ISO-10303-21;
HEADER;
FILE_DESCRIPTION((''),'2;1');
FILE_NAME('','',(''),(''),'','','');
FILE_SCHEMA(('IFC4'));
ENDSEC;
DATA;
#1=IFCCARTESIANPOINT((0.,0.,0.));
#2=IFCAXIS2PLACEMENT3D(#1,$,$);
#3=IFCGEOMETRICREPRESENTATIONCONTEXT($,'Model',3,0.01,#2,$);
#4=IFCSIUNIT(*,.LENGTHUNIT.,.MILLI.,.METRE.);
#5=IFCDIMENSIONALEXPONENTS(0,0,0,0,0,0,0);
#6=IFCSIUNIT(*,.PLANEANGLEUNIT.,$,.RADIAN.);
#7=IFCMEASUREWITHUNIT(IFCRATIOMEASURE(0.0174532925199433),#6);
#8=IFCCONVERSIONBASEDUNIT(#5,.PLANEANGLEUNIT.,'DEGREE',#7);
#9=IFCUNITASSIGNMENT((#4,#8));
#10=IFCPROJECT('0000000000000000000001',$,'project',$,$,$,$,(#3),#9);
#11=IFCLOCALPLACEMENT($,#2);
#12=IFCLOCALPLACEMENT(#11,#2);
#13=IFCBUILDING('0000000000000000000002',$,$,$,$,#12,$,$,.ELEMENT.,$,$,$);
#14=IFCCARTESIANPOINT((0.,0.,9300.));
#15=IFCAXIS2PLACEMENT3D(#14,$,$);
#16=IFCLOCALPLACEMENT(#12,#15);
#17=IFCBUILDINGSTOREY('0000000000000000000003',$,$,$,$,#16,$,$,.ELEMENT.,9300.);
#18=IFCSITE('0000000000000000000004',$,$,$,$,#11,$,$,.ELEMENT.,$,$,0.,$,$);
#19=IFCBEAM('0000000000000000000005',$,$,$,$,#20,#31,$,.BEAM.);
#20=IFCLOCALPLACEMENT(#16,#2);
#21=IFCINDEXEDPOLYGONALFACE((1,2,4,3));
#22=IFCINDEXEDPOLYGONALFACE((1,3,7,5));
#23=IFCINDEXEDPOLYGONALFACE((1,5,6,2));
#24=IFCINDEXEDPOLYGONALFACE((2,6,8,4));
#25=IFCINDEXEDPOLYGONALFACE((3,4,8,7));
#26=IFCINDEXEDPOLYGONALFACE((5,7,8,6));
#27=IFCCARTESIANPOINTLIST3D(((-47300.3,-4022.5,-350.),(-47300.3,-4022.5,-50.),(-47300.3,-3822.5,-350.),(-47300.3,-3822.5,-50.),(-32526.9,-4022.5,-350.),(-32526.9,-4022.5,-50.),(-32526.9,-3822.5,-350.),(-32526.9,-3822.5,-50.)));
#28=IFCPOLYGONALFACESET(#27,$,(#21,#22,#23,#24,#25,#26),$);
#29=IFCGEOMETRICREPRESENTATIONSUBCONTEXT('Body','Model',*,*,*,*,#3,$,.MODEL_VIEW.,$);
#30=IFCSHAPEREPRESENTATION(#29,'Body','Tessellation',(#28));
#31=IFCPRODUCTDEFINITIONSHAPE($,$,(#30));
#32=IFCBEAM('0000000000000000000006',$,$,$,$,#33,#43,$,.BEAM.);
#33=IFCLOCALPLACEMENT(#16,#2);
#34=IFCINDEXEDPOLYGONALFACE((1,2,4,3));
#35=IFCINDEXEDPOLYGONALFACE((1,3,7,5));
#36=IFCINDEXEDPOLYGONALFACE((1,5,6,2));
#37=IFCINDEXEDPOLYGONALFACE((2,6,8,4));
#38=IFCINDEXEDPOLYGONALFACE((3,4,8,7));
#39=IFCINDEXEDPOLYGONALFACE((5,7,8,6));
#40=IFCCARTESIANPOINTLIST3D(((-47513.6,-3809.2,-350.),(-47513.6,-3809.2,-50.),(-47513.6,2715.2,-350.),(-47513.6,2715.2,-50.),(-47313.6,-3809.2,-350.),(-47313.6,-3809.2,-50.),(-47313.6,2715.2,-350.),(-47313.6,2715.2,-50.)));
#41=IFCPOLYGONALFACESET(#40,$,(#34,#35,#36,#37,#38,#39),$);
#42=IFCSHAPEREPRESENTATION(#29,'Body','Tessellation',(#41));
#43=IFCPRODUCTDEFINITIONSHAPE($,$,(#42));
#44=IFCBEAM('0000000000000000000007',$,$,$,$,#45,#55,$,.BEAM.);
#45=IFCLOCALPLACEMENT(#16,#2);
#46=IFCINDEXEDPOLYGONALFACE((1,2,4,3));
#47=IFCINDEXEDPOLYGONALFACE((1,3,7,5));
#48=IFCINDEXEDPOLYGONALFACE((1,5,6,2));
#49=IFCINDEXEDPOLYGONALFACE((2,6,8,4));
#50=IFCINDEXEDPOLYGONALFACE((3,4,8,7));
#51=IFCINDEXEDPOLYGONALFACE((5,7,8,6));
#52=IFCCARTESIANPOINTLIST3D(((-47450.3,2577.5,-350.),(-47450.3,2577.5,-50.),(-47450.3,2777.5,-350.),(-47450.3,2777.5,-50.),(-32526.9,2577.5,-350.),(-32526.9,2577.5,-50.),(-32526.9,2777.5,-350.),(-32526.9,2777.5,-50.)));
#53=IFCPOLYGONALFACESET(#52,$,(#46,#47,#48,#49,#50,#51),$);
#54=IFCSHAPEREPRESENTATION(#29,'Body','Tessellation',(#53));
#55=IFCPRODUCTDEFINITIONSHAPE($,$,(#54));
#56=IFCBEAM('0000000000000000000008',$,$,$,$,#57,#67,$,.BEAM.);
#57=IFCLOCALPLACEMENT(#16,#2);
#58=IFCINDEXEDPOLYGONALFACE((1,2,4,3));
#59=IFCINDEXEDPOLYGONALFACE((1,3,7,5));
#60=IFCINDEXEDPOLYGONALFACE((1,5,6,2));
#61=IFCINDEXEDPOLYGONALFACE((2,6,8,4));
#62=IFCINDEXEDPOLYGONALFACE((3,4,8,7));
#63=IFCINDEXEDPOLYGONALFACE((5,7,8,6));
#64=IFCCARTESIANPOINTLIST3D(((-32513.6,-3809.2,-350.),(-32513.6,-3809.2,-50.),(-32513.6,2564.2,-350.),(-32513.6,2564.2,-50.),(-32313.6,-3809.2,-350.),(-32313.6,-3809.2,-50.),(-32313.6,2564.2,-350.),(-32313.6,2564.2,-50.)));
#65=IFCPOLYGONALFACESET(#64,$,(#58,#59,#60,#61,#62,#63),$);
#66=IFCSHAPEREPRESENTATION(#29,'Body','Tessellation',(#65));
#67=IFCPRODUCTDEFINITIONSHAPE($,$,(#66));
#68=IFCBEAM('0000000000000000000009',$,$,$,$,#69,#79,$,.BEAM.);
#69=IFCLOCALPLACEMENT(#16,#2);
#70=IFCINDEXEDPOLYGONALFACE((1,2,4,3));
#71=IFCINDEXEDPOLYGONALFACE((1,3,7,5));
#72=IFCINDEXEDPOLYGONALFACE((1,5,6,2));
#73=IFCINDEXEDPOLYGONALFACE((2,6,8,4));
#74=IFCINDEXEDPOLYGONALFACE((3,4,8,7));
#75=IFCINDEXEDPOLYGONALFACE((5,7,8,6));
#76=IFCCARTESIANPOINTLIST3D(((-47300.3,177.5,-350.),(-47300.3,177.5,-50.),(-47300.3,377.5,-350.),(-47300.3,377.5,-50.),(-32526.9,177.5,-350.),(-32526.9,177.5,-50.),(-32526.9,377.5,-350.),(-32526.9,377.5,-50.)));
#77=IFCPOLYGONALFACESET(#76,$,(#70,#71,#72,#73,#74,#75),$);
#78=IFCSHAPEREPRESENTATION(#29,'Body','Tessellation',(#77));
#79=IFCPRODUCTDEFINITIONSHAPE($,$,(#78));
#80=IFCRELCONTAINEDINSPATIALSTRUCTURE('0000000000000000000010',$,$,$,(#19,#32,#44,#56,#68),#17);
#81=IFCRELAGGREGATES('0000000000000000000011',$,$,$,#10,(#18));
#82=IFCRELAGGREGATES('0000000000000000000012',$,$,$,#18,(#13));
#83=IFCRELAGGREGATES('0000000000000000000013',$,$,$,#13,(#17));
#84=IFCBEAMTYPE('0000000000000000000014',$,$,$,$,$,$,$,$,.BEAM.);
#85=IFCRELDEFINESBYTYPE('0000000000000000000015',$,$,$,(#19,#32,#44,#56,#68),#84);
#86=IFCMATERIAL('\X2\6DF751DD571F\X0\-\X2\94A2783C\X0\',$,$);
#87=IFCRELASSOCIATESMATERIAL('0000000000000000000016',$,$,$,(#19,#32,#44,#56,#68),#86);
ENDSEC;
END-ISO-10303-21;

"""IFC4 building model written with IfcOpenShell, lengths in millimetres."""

from ifc_helpers import new_model, entity, si_unit, converted_unit, frame, frame_2d, origin, place, context, subcontext, project, spatial, rectangle, extrude, material, type_object, element, save


model = new_model("IFC4")

# Units and contexts
model_context = context("Model", 3, precision=0.01, world=origin())
body_context = subcontext(model_context, "Body", "Model", "MODEL_VIEW")
ifc_project = project(units=[si_unit("LENGTHUNIT", "METRE", prefix="MILLI"), converted_unit("PLANEANGLEUNIT", "DEGREE", entity("IfcRatioMeasure", 0.0174532925199433), si_unit("PLANEANGLEUNIT", "RADIAN"), dimensions=[0, 0, 0, 0, 0, 0, 0])], contexts=[model_context])

# Site, building, storey
site_placement = place(None, origin())
site = spatial("IfcSite", under=ifc_project, at=site_placement, CompositionType="ELEMENT", RefElevation=0.0)
building_placement = place(site_placement, origin())
building = spatial("IfcBuilding", under=site, at=building_placement, CompositionType="ELEMENT")
storey_placement = place(building_placement, frame((0.0, 0.0, 9300.0)))
storey = spatial("IfcBuildingStorey", under=building, at=storey_placement, CompositionType="ELEMENT", Elevation=9300.0)

# Beams
ifc_material_1 = material(Name="混凝土-钢砼")
beam_type = type_object("IfcBeamType", PredefinedType="BEAM")
beam_1_placement = place(storey_placement, frame((-47413.6, -3922.5, -50.0)))
element("IfcBeam", 1, at=beam_1_placement, inside=storey, type_object=beam_type, material=ifc_material_1, PredefinedType="BEAM", context=body_context, shape_type="SweptSolid", body=[
    extrude(rectangle(XDim=300.0, YDim=200.0, at=frame_2d((0.0, 0.0), x_axis=(1.0, 0.0))), frame((113.3, 0.0, -150.0), z_axis=(1.0, 0.0, 0.0), x_axis=(0.0, 0.0, -1.0)), (0.0, 0.0, 1.0), 14773.4),
])
beam_2_placement = place(storey_placement, frame((-47413.6, -3922.5, -50.0), z_axis=(0.0, 0.0, 1.0), x_axis=(0.0, 1.0, 0.0)))
element("IfcBeam", 2, at=beam_2_placement, inside=storey, type_object=beam_type, material=ifc_material_1, PredefinedType="BEAM", context=body_context, shape_type="SweptSolid", body=[
    extrude(rectangle(XDim=300.0, YDim=200.0, at=frame_2d((0.0, 0.0), x_axis=(1.0, 0.0))), frame((113.3, 0.0, -150.0), z_axis=(1.0, 0.0, 0.0), x_axis=(0.0, 0.0, -1.0)), (0.0, 0.0, 1.0), 6524.4),
])
beam_3_placement = place(storey_placement, frame((-47413.6, 2677.5, -50.0)))
element("IfcBeam", 3, at=beam_3_placement, inside=storey, type_object=beam_type, material=ifc_material_1, PredefinedType="BEAM", context=body_context, shape_type="SweptSolid", body=[
    extrude(rectangle(XDim=300.0, YDim=200.0, at=frame_2d((0.0, 0.0), x_axis=(1.0, 0.0))), frame((-36.7, 0.0, -150.0), z_axis=(1.0, 0.0, 0.0), x_axis=(0.0, 0.0, -1.0)), (0.0, 0.0, 1.0), 14923.4),
])
beam_4_placement = place(storey_placement, frame((-32413.6, 2677.5, -50.0), z_axis=(0.0, 0.0, 1.0), x_axis=(0.0, -1.0, 0.0)))
element("IfcBeam", 4, at=beam_4_placement, inside=storey, type_object=beam_type, material=ifc_material_1, PredefinedType="BEAM", context=body_context, shape_type="SweptSolid", body=[
    extrude(rectangle(XDim=300.0, YDim=200.0, at=frame_2d((0.0, 0.0), x_axis=(1.0, 0.0))), frame((113.3, 0.0, -150.0), z_axis=(1.0, 0.0, 0.0), x_axis=(0.0, 0.0, -1.0)), (0.0, 0.0, 1.0), 6373.4),
])
beam_5_placement = place(storey_placement, frame((-32413.6, 277.5, -50.0), z_axis=(0.0, 0.0, 1.0), x_axis=(-1.0, 0.0, 0.0)))
element("IfcBeam", 5, at=beam_5_placement, inside=storey, type_object=beam_type, material=ifc_material_1, PredefinedType="BEAM", context=body_context, shape_type="SweptSolid", body=[
    extrude(rectangle(XDim=300.0, YDim=200.0, at=frame_2d((0.0, 0.0), x_axis=(1.0, 0.0))), frame((113.3, 0.0, -150.0), z_axis=(1.0, 0.0, 0.0), x_axis=(0.0, 0.0, -1.0)), (0.0, 0.0, 1.0), 14773.4),
])

save(model, "model.ifc")
